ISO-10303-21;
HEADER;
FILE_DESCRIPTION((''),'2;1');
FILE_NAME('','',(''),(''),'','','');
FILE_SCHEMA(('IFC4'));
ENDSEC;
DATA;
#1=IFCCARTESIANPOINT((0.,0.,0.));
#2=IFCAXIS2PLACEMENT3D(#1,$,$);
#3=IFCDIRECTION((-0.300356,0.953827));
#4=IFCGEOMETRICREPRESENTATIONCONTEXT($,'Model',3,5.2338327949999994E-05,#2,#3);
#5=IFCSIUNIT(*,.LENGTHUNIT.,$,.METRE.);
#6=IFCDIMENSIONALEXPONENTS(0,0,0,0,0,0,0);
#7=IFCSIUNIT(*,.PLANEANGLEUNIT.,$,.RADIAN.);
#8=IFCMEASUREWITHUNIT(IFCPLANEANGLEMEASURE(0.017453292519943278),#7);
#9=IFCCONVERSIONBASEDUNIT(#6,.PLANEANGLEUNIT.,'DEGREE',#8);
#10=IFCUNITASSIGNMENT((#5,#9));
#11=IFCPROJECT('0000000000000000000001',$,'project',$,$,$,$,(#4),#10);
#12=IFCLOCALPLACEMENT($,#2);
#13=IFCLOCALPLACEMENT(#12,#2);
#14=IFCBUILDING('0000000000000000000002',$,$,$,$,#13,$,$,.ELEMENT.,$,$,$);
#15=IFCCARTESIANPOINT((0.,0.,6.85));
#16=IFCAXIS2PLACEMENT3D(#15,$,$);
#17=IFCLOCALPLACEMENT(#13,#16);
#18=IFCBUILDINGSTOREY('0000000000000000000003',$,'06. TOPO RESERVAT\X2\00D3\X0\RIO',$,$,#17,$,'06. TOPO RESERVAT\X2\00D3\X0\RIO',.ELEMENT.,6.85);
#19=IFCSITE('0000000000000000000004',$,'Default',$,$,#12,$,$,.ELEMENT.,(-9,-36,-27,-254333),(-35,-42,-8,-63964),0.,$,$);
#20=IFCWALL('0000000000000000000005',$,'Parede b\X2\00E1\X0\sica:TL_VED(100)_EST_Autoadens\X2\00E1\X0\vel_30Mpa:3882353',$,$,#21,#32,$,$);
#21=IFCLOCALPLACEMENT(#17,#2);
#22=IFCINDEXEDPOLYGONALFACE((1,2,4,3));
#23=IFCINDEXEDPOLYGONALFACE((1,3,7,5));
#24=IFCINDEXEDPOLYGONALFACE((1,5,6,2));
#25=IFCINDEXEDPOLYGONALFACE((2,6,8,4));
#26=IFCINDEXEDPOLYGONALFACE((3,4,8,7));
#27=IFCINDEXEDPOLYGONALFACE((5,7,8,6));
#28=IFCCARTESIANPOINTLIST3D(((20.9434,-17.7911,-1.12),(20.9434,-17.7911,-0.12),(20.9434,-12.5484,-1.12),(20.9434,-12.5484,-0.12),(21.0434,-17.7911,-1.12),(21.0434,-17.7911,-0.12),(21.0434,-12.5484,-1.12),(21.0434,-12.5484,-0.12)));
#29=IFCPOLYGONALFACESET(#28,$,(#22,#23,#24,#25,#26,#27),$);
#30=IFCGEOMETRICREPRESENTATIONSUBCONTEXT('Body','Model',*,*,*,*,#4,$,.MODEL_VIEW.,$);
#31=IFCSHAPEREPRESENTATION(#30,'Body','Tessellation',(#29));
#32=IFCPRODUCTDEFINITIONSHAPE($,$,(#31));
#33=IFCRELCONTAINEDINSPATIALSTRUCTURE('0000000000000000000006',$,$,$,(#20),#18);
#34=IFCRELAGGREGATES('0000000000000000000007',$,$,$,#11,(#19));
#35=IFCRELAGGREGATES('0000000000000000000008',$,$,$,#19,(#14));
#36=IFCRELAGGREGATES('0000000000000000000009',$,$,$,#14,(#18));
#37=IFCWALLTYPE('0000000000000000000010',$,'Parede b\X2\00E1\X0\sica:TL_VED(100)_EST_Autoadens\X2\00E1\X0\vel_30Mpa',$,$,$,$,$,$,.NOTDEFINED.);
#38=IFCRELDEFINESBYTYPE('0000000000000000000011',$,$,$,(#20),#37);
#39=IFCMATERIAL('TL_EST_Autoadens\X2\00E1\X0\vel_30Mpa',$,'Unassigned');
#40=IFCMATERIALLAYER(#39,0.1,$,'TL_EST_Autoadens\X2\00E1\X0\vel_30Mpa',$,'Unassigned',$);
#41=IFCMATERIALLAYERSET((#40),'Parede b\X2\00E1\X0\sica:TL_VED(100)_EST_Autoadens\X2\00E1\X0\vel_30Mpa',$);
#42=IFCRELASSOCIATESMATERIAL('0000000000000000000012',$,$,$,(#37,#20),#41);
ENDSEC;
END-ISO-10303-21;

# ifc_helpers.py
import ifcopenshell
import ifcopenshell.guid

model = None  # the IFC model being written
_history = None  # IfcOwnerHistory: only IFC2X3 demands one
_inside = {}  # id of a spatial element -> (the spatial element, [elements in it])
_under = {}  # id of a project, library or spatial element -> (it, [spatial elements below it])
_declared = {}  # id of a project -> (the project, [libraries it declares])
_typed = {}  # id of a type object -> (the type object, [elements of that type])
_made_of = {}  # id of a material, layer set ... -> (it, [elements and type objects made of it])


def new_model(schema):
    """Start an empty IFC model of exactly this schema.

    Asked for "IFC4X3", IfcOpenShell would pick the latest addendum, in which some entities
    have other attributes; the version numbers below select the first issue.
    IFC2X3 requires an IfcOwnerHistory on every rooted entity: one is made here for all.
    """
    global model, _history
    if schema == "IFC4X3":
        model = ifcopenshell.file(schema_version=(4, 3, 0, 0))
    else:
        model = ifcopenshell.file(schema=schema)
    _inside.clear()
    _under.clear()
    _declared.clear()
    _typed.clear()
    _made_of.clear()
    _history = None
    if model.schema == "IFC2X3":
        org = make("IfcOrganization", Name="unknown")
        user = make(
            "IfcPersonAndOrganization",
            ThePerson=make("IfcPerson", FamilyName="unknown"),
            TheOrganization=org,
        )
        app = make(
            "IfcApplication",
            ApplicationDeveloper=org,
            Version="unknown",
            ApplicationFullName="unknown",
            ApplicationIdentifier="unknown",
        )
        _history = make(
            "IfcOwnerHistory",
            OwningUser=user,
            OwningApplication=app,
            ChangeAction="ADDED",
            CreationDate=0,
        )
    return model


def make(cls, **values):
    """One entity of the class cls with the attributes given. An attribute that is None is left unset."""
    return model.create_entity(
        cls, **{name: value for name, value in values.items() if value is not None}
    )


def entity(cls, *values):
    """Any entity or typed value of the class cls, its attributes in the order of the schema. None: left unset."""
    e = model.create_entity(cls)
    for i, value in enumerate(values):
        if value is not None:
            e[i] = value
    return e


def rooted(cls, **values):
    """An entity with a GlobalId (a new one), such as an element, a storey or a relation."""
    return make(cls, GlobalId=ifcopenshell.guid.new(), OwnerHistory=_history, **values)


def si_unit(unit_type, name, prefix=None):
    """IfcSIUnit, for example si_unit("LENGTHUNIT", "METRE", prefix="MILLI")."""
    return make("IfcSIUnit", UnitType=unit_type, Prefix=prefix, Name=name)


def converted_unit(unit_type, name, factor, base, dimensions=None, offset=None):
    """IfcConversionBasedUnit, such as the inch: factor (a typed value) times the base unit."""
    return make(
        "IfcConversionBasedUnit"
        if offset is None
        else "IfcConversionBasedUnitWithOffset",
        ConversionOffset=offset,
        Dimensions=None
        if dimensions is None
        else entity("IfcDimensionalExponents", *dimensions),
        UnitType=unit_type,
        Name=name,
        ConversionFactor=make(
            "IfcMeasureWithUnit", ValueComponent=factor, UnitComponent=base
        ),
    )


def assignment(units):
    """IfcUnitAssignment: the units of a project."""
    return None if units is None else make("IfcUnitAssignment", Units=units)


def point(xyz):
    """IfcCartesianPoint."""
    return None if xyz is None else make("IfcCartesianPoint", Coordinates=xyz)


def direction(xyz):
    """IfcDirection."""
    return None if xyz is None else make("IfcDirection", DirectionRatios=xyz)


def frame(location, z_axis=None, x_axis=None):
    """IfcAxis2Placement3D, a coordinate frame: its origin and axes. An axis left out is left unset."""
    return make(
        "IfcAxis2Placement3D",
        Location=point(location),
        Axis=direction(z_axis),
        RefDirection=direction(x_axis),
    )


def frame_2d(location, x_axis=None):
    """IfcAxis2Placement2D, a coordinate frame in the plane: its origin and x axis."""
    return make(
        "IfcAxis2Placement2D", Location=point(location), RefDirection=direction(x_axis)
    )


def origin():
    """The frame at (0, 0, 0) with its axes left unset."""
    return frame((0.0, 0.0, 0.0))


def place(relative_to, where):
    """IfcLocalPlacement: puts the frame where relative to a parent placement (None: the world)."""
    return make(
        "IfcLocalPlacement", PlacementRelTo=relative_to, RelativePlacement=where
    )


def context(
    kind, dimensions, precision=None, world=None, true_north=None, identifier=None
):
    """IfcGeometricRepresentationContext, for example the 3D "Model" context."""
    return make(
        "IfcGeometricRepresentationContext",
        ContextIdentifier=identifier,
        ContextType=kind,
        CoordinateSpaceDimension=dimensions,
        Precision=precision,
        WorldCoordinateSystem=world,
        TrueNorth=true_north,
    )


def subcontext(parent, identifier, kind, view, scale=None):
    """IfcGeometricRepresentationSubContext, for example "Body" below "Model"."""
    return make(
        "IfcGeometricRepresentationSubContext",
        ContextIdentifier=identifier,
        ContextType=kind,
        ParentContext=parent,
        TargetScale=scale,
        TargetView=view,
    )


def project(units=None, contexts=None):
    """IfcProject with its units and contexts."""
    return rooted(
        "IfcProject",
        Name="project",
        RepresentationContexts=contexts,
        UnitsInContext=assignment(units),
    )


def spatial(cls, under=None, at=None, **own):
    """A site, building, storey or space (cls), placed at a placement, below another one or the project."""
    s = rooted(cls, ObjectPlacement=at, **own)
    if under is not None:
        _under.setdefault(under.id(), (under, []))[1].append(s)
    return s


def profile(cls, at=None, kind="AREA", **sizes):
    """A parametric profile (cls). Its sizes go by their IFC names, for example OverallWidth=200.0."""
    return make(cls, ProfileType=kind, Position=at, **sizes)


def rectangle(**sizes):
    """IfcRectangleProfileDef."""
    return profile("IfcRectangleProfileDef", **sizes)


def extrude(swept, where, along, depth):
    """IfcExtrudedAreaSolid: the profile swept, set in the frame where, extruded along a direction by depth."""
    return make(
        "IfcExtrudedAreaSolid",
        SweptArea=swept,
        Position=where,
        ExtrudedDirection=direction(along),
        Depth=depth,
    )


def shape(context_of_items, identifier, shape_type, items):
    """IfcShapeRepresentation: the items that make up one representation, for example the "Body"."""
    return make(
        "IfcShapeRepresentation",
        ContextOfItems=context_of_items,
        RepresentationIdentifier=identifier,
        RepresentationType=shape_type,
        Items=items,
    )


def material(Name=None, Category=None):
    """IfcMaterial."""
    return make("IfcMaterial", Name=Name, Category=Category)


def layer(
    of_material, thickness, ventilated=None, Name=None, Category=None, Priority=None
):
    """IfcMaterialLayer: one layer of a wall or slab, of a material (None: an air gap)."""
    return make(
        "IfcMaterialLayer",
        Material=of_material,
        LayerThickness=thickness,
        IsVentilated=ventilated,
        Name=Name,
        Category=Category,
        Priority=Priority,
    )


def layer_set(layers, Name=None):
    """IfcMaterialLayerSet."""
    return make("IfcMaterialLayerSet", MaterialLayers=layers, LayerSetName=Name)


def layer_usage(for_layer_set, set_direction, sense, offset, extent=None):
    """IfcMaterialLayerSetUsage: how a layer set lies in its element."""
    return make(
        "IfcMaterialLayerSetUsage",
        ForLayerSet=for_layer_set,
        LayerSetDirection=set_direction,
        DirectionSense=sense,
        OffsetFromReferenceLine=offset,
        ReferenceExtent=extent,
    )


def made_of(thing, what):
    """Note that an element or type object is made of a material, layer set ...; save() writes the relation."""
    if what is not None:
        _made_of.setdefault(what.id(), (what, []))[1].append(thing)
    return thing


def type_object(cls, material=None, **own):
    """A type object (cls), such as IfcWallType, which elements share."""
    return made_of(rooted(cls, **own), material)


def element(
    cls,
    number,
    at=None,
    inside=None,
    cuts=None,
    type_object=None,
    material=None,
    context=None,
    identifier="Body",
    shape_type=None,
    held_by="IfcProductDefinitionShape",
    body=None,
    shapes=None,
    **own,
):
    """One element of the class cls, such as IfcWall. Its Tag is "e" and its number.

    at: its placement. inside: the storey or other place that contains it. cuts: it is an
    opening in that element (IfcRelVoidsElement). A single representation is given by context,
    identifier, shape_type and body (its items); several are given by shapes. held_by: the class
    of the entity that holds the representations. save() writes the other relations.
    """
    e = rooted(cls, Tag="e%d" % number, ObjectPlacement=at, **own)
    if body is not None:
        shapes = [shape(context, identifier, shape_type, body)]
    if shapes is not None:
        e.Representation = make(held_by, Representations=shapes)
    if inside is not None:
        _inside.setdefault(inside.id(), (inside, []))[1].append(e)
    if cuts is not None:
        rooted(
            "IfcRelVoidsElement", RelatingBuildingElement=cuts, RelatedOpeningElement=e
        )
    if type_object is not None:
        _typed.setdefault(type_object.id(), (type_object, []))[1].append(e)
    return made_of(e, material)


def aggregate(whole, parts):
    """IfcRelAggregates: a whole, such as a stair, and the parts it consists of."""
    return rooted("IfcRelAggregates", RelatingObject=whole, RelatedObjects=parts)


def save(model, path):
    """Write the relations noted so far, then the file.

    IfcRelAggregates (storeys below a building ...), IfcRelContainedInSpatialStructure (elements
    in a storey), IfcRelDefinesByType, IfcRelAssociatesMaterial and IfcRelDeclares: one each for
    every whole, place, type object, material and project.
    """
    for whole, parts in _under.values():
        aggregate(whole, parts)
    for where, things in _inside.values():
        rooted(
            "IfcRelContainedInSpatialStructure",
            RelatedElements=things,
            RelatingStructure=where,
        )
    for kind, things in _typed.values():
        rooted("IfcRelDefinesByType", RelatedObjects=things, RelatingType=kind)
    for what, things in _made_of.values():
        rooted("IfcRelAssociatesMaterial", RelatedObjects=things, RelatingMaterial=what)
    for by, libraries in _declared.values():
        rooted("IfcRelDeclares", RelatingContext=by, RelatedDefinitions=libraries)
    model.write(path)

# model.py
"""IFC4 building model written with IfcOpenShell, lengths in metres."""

from ifc_helpers import new_model, entity, si_unit, converted_unit, direction, frame, frame_2d, origin, place, context, subcontext, project, spatial, rectangle, extrude, material, layer, layer_set, layer_usage, type_object, element, save


model = new_model("IFC4")

# Units and contexts
model_context = context("Model", 3, precision=5.2338327949999994e-05, world=origin(), true_north=direction((-0.300356, 0.953827)))
body_context = subcontext(model_context, "Body", "Model", "MODEL_VIEW")
ifc_project = project(units=[si_unit("LENGTHUNIT", "METRE"), converted_unit("PLANEANGLEUNIT", "DEGREE", entity("IfcPlaneAngleMeasure", 0.017453292519943278), si_unit("PLANEANGLEUNIT", "RADIAN"), dimensions=[0, 0, 0, 0, 0, 0, 0])], contexts=[model_context])

# Site, building, storey
site_placement = place(None, origin())
site = spatial("IfcSite", under=ifc_project, at=site_placement, Name="Default", CompositionType="ELEMENT", RefLatitude=(-9, -36, -27, -254333), RefLongitude=(-35, -42, -8, -63964), RefElevation=0.0)
building_placement = place(site_placement, origin())
building = spatial("IfcBuilding", under=site, at=building_placement, CompositionType="ELEMENT")
storey_placement = place(building_placement, frame((0.0, 0.0, 6.85)))
storey = spatial("IfcBuildingStorey", under=building, at=storey_placement, Name="06. TOPO RESERVATÓRIO", LongName="06. TOPO RESERVATÓRIO", CompositionType="ELEMENT", Elevation=6.85)

# Wall
ifc_material_1 = material(Name="TL_EST_Autoadensável_30Mpa", Category="Unassigned")
ifc_layer = layer(ifc_material_1, 0.1, Name="TL_EST_Autoadensável_30Mpa", Category="Unassigned")
ifc_layer_set = layer_set([ifc_layer], Name="Parede básica:TL_VED(100)_EST_Autoadensável_30Mpa")
ifc_layer_usage = layer_usage(ifc_layer_set, "AXIS2", "POSITIVE", -0.05)
wall_type = type_object("IfcWallType", Name="Parede básica:TL_VED(100)_EST_Autoadensável_30Mpa", PredefinedType="NOTDEFINED", material=ifc_layer_set)
wall_placement = place(storey_placement, frame((20.9934, -12.5484, -1.12), z_axis=(0.0, 0.0, 1.0), x_axis=(0.0, -1.0, 0.0)))
element("IfcWall", 1, at=wall_placement, inside=storey, type_object=wall_type, material=ifc_layer_usage, Name="Parede básica:TL_VED(100)_EST_Autoadensável_30Mpa:3882353", context=body_context, shape_type="SweptSolid", body=[
    extrude(rectangle(XDim=5.2427, YDim=0.1, at=frame_2d((2.6214, 0.0), x_axis=(-1.0, 0.0))), origin(), (0.0, 0.0, 1.0), 1.0),
])

save(model, "model.ifc")
